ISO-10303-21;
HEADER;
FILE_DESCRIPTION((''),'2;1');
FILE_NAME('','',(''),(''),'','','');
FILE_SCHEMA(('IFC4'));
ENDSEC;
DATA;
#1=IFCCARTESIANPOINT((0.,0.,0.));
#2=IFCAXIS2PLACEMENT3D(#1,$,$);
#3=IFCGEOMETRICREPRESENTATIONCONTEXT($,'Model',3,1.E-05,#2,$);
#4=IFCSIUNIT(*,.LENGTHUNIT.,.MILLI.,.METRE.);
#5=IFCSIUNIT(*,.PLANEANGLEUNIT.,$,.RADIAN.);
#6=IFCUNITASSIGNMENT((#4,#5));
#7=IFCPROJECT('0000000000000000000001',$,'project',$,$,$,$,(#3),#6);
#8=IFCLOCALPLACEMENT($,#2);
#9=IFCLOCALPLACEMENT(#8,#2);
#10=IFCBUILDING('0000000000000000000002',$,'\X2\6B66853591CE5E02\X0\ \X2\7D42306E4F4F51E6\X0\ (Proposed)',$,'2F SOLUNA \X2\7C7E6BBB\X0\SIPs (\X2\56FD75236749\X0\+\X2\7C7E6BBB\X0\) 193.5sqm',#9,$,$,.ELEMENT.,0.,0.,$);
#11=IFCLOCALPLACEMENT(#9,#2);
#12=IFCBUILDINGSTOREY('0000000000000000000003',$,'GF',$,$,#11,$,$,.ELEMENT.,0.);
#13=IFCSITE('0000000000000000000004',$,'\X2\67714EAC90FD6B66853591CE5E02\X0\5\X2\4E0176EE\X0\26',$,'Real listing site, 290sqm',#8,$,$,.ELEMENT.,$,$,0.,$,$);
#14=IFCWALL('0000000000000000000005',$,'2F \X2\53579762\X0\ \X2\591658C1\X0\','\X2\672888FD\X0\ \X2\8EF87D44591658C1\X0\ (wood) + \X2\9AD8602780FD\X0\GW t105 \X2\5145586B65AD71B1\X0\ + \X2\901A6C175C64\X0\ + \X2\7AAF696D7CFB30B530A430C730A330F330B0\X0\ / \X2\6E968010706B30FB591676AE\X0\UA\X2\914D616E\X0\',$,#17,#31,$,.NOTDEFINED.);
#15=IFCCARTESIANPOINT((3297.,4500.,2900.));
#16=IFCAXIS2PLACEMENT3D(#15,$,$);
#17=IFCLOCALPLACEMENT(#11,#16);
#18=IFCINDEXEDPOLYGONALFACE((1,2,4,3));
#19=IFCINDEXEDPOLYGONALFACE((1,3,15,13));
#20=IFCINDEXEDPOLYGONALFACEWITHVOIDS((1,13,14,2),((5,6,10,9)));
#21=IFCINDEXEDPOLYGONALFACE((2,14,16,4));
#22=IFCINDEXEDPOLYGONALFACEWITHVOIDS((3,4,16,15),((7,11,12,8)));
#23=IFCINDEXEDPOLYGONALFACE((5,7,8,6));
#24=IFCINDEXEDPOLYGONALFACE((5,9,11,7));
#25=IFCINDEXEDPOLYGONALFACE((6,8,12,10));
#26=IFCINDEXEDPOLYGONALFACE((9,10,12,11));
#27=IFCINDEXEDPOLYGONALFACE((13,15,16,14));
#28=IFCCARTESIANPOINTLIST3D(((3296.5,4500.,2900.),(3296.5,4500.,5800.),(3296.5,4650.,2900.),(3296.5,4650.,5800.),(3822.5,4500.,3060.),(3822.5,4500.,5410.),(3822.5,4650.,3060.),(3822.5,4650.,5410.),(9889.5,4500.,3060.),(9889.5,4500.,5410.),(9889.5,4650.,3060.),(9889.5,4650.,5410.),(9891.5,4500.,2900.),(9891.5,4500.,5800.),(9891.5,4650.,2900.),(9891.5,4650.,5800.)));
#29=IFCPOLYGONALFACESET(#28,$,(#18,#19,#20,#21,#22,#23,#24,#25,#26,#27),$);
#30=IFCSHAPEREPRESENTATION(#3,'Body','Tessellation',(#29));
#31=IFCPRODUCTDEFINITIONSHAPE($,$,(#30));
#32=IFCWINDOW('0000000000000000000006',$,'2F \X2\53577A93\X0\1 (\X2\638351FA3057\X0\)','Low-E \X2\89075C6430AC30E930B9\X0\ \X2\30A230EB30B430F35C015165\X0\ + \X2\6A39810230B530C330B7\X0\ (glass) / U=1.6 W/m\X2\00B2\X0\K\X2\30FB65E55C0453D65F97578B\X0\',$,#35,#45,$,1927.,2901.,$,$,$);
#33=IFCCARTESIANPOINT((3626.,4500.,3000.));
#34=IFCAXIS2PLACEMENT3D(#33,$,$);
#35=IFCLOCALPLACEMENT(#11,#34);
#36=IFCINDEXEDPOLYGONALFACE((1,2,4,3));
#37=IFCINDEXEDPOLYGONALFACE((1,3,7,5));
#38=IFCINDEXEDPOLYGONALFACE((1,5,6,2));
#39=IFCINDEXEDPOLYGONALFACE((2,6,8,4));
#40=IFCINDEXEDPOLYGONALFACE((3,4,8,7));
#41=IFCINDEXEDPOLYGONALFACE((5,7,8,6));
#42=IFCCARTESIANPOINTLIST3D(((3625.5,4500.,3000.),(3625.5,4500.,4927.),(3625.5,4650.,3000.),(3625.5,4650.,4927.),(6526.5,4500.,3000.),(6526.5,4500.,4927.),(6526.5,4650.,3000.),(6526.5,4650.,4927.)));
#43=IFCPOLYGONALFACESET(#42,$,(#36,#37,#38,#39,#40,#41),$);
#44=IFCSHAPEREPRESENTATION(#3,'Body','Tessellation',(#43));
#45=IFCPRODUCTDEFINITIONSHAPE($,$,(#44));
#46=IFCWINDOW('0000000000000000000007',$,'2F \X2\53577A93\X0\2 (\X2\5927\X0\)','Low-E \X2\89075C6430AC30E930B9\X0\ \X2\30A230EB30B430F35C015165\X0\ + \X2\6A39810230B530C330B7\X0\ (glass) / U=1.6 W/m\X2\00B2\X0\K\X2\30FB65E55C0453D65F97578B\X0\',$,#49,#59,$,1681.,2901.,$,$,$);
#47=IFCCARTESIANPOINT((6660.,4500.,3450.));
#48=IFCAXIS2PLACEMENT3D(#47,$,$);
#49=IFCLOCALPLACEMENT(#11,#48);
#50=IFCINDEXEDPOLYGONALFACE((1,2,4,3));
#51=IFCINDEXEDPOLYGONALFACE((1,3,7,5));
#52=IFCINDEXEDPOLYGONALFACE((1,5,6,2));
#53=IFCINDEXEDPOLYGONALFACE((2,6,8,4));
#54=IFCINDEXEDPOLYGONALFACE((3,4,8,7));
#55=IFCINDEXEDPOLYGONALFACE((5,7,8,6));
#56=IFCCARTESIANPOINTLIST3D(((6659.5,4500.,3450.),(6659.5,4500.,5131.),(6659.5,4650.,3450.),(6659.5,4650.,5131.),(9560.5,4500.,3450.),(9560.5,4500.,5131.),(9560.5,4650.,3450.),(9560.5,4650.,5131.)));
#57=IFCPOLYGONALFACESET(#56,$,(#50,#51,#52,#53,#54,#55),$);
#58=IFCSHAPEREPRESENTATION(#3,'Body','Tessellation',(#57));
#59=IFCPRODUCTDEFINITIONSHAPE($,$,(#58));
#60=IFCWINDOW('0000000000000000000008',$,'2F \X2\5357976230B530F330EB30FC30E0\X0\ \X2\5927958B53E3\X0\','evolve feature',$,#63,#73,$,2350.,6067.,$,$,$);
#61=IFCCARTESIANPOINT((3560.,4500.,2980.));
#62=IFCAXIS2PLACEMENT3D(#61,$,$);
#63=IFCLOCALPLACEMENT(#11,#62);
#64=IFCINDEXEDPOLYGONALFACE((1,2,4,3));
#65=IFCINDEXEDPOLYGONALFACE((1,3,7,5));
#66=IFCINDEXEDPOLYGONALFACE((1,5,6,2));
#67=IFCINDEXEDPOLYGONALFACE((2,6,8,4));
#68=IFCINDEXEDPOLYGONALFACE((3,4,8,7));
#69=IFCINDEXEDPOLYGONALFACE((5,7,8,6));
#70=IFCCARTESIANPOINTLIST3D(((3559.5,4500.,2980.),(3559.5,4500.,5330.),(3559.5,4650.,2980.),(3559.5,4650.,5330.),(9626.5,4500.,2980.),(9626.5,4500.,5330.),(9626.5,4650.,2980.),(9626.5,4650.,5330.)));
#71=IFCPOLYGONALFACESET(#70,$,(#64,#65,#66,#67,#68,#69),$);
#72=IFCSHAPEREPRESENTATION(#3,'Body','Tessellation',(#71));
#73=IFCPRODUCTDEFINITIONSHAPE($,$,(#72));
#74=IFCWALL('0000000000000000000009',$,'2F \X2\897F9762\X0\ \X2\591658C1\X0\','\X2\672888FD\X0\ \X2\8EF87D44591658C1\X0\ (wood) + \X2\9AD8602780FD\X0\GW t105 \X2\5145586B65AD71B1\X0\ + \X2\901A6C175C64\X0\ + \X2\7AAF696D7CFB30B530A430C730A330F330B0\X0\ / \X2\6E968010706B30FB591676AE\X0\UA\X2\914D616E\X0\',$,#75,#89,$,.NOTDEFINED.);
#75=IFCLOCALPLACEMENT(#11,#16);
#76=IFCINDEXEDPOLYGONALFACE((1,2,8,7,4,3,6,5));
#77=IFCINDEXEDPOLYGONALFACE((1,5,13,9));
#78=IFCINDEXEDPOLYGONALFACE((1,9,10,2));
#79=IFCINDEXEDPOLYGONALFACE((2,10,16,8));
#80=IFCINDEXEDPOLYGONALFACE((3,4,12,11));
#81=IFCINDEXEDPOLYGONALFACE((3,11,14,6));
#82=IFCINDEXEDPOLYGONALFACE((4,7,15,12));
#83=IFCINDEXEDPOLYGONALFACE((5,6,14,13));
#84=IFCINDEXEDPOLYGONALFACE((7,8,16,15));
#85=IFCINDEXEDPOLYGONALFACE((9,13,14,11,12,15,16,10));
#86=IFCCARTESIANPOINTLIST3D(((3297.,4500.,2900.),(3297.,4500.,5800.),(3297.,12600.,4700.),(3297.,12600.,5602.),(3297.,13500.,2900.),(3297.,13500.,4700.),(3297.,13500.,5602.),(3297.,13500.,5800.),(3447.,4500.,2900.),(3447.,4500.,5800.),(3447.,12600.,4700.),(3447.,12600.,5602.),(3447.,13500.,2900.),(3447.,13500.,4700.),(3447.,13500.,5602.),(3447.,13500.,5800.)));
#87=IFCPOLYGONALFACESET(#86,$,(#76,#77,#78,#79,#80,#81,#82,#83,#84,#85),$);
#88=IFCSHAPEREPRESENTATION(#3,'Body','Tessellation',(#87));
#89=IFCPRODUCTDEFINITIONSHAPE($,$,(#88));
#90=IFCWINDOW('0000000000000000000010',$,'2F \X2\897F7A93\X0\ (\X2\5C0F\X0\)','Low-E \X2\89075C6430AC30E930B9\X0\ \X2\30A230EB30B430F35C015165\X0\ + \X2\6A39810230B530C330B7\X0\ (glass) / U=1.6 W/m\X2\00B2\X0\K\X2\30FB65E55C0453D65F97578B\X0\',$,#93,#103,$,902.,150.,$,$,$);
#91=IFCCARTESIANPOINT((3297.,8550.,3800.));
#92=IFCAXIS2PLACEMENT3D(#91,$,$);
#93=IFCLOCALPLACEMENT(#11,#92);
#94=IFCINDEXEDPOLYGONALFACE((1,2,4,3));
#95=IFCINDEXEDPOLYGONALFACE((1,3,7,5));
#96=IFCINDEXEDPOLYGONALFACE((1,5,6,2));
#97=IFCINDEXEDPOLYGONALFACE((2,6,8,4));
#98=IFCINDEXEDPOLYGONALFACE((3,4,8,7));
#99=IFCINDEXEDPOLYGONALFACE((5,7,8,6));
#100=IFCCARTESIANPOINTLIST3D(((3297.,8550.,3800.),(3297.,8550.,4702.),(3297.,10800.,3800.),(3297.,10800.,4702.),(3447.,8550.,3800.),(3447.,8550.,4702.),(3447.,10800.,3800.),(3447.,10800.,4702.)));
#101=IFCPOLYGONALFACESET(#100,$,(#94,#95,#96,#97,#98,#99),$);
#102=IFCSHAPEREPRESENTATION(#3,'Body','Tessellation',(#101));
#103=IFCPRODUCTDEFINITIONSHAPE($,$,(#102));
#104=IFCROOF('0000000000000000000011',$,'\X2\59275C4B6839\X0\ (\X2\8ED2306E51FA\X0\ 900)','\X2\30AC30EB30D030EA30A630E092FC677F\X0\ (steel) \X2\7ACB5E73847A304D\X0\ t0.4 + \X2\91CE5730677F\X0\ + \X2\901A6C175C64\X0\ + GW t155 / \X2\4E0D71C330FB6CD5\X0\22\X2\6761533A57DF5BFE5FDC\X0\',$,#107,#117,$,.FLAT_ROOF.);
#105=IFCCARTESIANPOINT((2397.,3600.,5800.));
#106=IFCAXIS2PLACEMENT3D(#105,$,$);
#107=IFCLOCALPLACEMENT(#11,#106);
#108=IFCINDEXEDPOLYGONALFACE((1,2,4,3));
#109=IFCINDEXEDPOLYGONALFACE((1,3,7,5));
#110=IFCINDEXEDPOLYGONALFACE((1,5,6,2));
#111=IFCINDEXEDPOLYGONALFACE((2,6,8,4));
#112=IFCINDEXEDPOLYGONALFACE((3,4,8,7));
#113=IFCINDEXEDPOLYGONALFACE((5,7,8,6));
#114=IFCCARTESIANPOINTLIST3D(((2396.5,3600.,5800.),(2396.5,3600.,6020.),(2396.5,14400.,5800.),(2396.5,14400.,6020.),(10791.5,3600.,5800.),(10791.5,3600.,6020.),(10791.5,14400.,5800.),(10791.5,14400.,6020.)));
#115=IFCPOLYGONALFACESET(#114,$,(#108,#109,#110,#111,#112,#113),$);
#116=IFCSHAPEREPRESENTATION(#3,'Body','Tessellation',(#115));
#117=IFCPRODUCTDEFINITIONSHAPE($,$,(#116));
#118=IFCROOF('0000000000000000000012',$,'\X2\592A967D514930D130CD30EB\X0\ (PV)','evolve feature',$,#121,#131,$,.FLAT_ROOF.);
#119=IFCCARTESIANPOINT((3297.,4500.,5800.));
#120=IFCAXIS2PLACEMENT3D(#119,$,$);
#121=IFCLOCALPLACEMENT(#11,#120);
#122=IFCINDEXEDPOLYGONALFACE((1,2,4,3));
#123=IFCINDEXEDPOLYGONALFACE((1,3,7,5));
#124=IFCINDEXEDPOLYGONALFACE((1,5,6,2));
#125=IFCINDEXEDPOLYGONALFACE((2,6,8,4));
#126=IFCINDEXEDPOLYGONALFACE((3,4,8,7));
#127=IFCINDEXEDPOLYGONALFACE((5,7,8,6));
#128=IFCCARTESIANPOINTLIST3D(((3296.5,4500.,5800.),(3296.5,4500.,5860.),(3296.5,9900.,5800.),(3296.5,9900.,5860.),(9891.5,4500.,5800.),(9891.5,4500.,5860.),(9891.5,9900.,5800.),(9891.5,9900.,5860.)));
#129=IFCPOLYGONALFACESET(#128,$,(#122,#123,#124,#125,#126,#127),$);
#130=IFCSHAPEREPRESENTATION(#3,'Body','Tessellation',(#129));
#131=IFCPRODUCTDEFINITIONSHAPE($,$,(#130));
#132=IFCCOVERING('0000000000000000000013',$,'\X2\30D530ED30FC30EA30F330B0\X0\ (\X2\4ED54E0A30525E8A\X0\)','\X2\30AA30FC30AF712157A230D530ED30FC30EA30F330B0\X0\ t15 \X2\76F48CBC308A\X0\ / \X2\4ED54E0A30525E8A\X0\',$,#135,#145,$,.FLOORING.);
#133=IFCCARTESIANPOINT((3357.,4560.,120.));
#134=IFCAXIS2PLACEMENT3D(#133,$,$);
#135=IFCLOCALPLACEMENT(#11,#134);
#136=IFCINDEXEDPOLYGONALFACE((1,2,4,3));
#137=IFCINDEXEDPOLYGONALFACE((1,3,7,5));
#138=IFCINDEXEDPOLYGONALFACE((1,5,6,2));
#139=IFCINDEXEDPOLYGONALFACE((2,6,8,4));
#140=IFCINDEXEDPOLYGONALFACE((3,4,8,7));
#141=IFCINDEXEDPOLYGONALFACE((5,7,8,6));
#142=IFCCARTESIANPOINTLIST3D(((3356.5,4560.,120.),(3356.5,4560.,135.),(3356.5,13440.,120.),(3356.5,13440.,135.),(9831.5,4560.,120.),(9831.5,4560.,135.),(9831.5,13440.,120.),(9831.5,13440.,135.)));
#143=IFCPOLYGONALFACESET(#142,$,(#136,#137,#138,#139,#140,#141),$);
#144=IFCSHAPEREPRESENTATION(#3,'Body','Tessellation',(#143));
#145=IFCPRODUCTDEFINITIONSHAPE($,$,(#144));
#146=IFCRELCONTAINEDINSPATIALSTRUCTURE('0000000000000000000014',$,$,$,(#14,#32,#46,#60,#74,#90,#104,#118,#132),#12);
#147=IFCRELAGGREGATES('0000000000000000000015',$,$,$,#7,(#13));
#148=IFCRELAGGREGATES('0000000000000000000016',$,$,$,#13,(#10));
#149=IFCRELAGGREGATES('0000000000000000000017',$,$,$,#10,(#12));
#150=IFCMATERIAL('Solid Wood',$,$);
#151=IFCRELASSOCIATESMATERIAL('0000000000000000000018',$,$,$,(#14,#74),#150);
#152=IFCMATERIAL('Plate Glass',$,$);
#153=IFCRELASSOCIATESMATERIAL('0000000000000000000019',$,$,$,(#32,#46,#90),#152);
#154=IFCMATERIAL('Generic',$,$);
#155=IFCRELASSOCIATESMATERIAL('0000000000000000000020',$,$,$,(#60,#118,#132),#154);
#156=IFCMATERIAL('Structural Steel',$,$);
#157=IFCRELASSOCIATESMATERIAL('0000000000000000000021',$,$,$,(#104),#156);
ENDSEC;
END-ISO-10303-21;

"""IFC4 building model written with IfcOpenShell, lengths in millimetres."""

from ifc_helpers import new_model, si_unit, frame, frame_2d, origin, place, context, project, spatial, rectangle, extrude, material, element, fill, save


model = new_model("IFC4")

# Units and contexts
model_context = context("Model", 3, precision=1e-05, world=origin())
ifc_project = project(units=[si_unit("LENGTHUNIT", "METRE", prefix="MILLI"), si_unit("PLANEANGLEUNIT", "RADIAN")], contexts=[model_context])

# Site, building, storey
site_placement = place(None, origin())
site = spatial("IfcSite", under=ifc_project, at=site_placement, Name="東京都武蔵野市5丁目26", ObjectType="Real listing site, 290sqm", CompositionType="ELEMENT", RefElevation=0.0)
building_placement = place(site_placement, origin())
building = spatial("IfcBuilding", under=site, at=building_placement, Name="武蔵野市 終の住処 (Proposed)", ObjectType="2F SOLUNA 籾殻SIPs (国産杉+籾殻) 193.5sqm", CompositionType="ELEMENT", ElevationOfRefHeight=0.0, ElevationOfTerrain=0.0)
storey_placement = place(building_placement, origin())
storey = spatial("IfcBuildingStorey", under=building, at=storey_placement, Name="GF", CompositionType="ELEMENT", Elevation=0.0)

# Shared definitions
ifc_material_1 = material(Name="Solid Wood")

# Shared definitions
ifc_material_2 = material(Name="Plate Glass")
ifc_material_3 = material(Name="Generic")

# Wall, openings, windows
wall_1_placement = place(storey_placement, frame((3297.0, 4500.0, 2900.0)))
wall_1 = element("IfcWall", 1, at=wall_1_placement, inside=storey, material=ifc_material_1, Name="2F 南面 外壁", Description="木製 軸組外壁 (wood) + 高性能GW t105 充填断熱 + 通気層 + 窯業系サイディング / 準耐火・外皮UA配慮", PredefinedType="NOTDEFINED", context=model_context, shape_type="SweptSolid", body=[
    extrude(rectangle(XDim=6595.0, YDim=150.0, at=frame_2d((3297.0, 75.0))), frame((3297.0, 4500.0, 2900.0)), (0.0, 0.0, 1.0), 2900.0),
])
opening_1_placement = place(storey_placement, frame((3626.0, 4500.0, 3000.0)))
opening_1 = element("IfcOpeningElement", 2, at=opening_1_placement, cuts=wall_1, PredefinedType="NOTDEFINED", context=model_context, shape_type="SweptSolid", body=[
    extrude(rectangle(XDim=2901.0, YDim=150.0, at=frame_2d((1450.0, 75.0))), frame((3626.0, 4500.0, 3000.0)), (0.0, 0.0, 1.0), 1927.0),
])
opening_2_placement = place(storey_placement, frame((6660.0, 4500.0, 3450.0)))
opening_2 = element("IfcOpeningElement", 3, at=opening_2_placement, cuts=wall_1, PredefinedType="NOTDEFINED", context=model_context, shape_type="SweptSolid", body=[
    extrude(rectangle(XDim=2901.0, YDim=150.0, at=frame_2d((1450.0, 75.0))), frame((6660.0, 4500.0, 3450.0)), (0.0, 0.0, 1.0), 1681.0),
])
opening_3_placement = place(storey_placement, frame((3560.0, 4500.0, 2980.0)))
opening_3 = element("IfcOpeningElement", 4, at=opening_3_placement, cuts=wall_1, PredefinedType="NOTDEFINED", context=model_context, shape_type="SweptSolid", body=[
    extrude(rectangle(XDim=6067.0, YDim=150.0, at=frame_2d((3033.0, 75.0))), frame((3560.0, 4500.0, 2980.0)), (0.0, 0.0, 1.0), 2350.0),
])
window_1_placement = place(storey_placement, frame((3626.0, 4500.0, 3000.0)))
window_1 = element("IfcWindow", 5, at=window_1_placement, inside=storey, material=ifc_material_2, Name="2F 南窓1 (掃出し)", Description="Low-E 複層ガラス アルゴン封入 + 樹脂サッシ (glass) / U=1.6 W/m²K・日射取得型", OverallHeight=1927.0, OverallWidth=2901.0, context=model_context, shape_type="SweptSolid", body=[
    extrude(rectangle(XDim=2901.0, YDim=150.0, at=frame_2d((1450.0, 75.0))), frame((3626.0, 4500.0, 3000.0)), (0.0, 0.0, 1.0), 1927.0),
])
fill(opening_1, window_1)
window_2_placement = place(storey_placement, frame((6660.0, 4500.0, 3450.0)))
window_2 = element("IfcWindow", 6, at=window_2_placement, inside=storey, material=ifc_material_2, Name="2F 南窓2 (大)", Description="Low-E 複層ガラス アルゴン封入 + 樹脂サッシ (glass) / U=1.6 W/m²K・日射取得型", OverallHeight=1681.0, OverallWidth=2901.0, context=model_context, shape_type="SweptSolid", body=[
    extrude(rectangle(XDim=2901.0, YDim=150.0, at=frame_2d((1450.0, 75.0))), frame((6660.0, 4500.0, 3450.0)), (0.0, 0.0, 1.0), 1681.0),
])
fill(opening_2, window_2)
window_3_placement = place(storey_placement, frame((3560.0, 4500.0, 2980.0)))
window_3 = element("IfcWindow", 7, at=window_3_placement, inside=storey, material=ifc_material_3, Name="2F 南面サンルーム 大開口", Description="evolve feature", OverallHeight=2350.0, OverallWidth=6067.0, context=model_context, shape_type="SweptSolid", body=[
    extrude(rectangle(XDim=6067.0, YDim=150.0, at=frame_2d((3033.0, 75.0))), frame((3560.0, 4500.0, 2980.0)), (0.0, 0.0, 1.0), 2350.0),
])
fill(opening_3, window_3)

# Wall, opening, window
wall_2_placement = place(storey_placement, frame((3297.0, 4500.0, 2900.0)))
wall_2 = element("IfcWall", 8, at=wall_2_placement, inside=storey, material=ifc_material_1, Name="2F 西面 外壁", Description="木製 軸組外壁 (wood) + 高性能GW t105 充填断熱 + 通気層 + 窯業系サイディング / 準耐火・外皮UA配慮", PredefinedType="NOTDEFINED", context=model_context, shape_type="SweptSolid", body=[
    extrude(rectangle(XDim=150.0, YDim=9000.0, at=frame_2d((75.0, 4500.0))), frame((3297.0, 4500.0, 2900.0)), (0.0, 0.0, 1.0), 2900.0),
])
opening_4_placement = place(storey_placement, frame((3297.0, 8550.0, 3800.0)))
opening_4 = element("IfcOpeningElement", 9, at=opening_4_placement, cuts=wall_2, PredefinedType="NOTDEFINED", context=model_context, shape_type="SweptSolid", body=[
    extrude(rectangle(XDim=150.0, YDim=2250.0, at=frame_2d((75.0, 1125.0))), frame((3297.0, 8550.0, 3800.0)), (0.0, 0.0, 1.0), 902.0),
])
window_4_placement = place(storey_placement, frame((3297.0, 8550.0, 3800.0)))
window_4 = element("IfcWindow", 10, at=window_4_placement, inside=storey, material=ifc_material_2, Name="2F 西窓 (小)", Description="Low-E 複層ガラス アルゴン封入 + 樹脂サッシ (glass) / U=1.6 W/m²K・日射取得型", OverallHeight=902.0, OverallWidth=150.0, context=model_context, shape_type="SweptSolid", body=[
    extrude(rectangle(XDim=150.0, YDim=2250.0, at=frame_2d((75.0, 1125.0))), frame((3297.0, 8550.0, 3800.0)), (0.0, 0.0, 1.0), 902.0),
])
fill(opening_4, window_4)

# Roofs
ifc_material_4 = material(Name="Structural Steel")
roof_1_placement = place(storey_placement, frame((2397.0, 3600.0, 5800.0)))
element("IfcRoof", 11, at=roof_1_placement, inside=storey, material=ifc_material_4, Name="大屋根 (軒の出 900)", Description="ガルバリウム鋼板 (steel) 立平葺き t0.4 + 野地板 + 通気層 + GW t155 / 不燃・法22条区域対応", PredefinedType="FLAT_ROOF", context=model_context, shape_type="SweptSolid", body=[
    extrude(rectangle(XDim=8395.0, YDim=10800.0, at=frame_2d((4197.0, 5400.0))), frame((2397.0, 3600.0, 5800.0)), (0.0, 0.0, 1.0), 220.0),
])
roof_2_placement = place(storey_placement, frame((3297.0, 4500.0, 5800.0)))
element("IfcRoof", 12, at=roof_2_placement, inside=storey, material=ifc_material_3, Name="太陽光パネル (PV)", Description="evolve feature", PredefinedType="FLAT_ROOF", context=model_context, shape_type="SweptSolid", body=[
    extrude(rectangle(XDim=6595.0, YDim=5400.0, at=frame_2d((3297.0, 2700.0))), frame((3297.0, 4500.0, 5800.0)), (0.0, 0.0, 1.0), 60.0),
])

# Covering
covering_placement = place(storey_placement, frame((3357.0, 4560.0, 120.0)))
element("IfcCovering", 13, at=covering_placement, inside=storey, material=ifc_material_3, Name="フローリング (仕上げ床)", Description="オーク無垢フローリング t15 直貼り / 仕上げ床", PredefinedType="FLOORING", context=model_context, shape_type="SweptSolid", body=[
    extrude(rectangle(XDim=6475.0, YDim=8880.0, at=frame_2d((3237.0, 4440.0))), frame((3357.0, 4560.0, 120.0)), (0.0, 0.0, 1.0), 15.0),
])

save(model, "model.ifc")
